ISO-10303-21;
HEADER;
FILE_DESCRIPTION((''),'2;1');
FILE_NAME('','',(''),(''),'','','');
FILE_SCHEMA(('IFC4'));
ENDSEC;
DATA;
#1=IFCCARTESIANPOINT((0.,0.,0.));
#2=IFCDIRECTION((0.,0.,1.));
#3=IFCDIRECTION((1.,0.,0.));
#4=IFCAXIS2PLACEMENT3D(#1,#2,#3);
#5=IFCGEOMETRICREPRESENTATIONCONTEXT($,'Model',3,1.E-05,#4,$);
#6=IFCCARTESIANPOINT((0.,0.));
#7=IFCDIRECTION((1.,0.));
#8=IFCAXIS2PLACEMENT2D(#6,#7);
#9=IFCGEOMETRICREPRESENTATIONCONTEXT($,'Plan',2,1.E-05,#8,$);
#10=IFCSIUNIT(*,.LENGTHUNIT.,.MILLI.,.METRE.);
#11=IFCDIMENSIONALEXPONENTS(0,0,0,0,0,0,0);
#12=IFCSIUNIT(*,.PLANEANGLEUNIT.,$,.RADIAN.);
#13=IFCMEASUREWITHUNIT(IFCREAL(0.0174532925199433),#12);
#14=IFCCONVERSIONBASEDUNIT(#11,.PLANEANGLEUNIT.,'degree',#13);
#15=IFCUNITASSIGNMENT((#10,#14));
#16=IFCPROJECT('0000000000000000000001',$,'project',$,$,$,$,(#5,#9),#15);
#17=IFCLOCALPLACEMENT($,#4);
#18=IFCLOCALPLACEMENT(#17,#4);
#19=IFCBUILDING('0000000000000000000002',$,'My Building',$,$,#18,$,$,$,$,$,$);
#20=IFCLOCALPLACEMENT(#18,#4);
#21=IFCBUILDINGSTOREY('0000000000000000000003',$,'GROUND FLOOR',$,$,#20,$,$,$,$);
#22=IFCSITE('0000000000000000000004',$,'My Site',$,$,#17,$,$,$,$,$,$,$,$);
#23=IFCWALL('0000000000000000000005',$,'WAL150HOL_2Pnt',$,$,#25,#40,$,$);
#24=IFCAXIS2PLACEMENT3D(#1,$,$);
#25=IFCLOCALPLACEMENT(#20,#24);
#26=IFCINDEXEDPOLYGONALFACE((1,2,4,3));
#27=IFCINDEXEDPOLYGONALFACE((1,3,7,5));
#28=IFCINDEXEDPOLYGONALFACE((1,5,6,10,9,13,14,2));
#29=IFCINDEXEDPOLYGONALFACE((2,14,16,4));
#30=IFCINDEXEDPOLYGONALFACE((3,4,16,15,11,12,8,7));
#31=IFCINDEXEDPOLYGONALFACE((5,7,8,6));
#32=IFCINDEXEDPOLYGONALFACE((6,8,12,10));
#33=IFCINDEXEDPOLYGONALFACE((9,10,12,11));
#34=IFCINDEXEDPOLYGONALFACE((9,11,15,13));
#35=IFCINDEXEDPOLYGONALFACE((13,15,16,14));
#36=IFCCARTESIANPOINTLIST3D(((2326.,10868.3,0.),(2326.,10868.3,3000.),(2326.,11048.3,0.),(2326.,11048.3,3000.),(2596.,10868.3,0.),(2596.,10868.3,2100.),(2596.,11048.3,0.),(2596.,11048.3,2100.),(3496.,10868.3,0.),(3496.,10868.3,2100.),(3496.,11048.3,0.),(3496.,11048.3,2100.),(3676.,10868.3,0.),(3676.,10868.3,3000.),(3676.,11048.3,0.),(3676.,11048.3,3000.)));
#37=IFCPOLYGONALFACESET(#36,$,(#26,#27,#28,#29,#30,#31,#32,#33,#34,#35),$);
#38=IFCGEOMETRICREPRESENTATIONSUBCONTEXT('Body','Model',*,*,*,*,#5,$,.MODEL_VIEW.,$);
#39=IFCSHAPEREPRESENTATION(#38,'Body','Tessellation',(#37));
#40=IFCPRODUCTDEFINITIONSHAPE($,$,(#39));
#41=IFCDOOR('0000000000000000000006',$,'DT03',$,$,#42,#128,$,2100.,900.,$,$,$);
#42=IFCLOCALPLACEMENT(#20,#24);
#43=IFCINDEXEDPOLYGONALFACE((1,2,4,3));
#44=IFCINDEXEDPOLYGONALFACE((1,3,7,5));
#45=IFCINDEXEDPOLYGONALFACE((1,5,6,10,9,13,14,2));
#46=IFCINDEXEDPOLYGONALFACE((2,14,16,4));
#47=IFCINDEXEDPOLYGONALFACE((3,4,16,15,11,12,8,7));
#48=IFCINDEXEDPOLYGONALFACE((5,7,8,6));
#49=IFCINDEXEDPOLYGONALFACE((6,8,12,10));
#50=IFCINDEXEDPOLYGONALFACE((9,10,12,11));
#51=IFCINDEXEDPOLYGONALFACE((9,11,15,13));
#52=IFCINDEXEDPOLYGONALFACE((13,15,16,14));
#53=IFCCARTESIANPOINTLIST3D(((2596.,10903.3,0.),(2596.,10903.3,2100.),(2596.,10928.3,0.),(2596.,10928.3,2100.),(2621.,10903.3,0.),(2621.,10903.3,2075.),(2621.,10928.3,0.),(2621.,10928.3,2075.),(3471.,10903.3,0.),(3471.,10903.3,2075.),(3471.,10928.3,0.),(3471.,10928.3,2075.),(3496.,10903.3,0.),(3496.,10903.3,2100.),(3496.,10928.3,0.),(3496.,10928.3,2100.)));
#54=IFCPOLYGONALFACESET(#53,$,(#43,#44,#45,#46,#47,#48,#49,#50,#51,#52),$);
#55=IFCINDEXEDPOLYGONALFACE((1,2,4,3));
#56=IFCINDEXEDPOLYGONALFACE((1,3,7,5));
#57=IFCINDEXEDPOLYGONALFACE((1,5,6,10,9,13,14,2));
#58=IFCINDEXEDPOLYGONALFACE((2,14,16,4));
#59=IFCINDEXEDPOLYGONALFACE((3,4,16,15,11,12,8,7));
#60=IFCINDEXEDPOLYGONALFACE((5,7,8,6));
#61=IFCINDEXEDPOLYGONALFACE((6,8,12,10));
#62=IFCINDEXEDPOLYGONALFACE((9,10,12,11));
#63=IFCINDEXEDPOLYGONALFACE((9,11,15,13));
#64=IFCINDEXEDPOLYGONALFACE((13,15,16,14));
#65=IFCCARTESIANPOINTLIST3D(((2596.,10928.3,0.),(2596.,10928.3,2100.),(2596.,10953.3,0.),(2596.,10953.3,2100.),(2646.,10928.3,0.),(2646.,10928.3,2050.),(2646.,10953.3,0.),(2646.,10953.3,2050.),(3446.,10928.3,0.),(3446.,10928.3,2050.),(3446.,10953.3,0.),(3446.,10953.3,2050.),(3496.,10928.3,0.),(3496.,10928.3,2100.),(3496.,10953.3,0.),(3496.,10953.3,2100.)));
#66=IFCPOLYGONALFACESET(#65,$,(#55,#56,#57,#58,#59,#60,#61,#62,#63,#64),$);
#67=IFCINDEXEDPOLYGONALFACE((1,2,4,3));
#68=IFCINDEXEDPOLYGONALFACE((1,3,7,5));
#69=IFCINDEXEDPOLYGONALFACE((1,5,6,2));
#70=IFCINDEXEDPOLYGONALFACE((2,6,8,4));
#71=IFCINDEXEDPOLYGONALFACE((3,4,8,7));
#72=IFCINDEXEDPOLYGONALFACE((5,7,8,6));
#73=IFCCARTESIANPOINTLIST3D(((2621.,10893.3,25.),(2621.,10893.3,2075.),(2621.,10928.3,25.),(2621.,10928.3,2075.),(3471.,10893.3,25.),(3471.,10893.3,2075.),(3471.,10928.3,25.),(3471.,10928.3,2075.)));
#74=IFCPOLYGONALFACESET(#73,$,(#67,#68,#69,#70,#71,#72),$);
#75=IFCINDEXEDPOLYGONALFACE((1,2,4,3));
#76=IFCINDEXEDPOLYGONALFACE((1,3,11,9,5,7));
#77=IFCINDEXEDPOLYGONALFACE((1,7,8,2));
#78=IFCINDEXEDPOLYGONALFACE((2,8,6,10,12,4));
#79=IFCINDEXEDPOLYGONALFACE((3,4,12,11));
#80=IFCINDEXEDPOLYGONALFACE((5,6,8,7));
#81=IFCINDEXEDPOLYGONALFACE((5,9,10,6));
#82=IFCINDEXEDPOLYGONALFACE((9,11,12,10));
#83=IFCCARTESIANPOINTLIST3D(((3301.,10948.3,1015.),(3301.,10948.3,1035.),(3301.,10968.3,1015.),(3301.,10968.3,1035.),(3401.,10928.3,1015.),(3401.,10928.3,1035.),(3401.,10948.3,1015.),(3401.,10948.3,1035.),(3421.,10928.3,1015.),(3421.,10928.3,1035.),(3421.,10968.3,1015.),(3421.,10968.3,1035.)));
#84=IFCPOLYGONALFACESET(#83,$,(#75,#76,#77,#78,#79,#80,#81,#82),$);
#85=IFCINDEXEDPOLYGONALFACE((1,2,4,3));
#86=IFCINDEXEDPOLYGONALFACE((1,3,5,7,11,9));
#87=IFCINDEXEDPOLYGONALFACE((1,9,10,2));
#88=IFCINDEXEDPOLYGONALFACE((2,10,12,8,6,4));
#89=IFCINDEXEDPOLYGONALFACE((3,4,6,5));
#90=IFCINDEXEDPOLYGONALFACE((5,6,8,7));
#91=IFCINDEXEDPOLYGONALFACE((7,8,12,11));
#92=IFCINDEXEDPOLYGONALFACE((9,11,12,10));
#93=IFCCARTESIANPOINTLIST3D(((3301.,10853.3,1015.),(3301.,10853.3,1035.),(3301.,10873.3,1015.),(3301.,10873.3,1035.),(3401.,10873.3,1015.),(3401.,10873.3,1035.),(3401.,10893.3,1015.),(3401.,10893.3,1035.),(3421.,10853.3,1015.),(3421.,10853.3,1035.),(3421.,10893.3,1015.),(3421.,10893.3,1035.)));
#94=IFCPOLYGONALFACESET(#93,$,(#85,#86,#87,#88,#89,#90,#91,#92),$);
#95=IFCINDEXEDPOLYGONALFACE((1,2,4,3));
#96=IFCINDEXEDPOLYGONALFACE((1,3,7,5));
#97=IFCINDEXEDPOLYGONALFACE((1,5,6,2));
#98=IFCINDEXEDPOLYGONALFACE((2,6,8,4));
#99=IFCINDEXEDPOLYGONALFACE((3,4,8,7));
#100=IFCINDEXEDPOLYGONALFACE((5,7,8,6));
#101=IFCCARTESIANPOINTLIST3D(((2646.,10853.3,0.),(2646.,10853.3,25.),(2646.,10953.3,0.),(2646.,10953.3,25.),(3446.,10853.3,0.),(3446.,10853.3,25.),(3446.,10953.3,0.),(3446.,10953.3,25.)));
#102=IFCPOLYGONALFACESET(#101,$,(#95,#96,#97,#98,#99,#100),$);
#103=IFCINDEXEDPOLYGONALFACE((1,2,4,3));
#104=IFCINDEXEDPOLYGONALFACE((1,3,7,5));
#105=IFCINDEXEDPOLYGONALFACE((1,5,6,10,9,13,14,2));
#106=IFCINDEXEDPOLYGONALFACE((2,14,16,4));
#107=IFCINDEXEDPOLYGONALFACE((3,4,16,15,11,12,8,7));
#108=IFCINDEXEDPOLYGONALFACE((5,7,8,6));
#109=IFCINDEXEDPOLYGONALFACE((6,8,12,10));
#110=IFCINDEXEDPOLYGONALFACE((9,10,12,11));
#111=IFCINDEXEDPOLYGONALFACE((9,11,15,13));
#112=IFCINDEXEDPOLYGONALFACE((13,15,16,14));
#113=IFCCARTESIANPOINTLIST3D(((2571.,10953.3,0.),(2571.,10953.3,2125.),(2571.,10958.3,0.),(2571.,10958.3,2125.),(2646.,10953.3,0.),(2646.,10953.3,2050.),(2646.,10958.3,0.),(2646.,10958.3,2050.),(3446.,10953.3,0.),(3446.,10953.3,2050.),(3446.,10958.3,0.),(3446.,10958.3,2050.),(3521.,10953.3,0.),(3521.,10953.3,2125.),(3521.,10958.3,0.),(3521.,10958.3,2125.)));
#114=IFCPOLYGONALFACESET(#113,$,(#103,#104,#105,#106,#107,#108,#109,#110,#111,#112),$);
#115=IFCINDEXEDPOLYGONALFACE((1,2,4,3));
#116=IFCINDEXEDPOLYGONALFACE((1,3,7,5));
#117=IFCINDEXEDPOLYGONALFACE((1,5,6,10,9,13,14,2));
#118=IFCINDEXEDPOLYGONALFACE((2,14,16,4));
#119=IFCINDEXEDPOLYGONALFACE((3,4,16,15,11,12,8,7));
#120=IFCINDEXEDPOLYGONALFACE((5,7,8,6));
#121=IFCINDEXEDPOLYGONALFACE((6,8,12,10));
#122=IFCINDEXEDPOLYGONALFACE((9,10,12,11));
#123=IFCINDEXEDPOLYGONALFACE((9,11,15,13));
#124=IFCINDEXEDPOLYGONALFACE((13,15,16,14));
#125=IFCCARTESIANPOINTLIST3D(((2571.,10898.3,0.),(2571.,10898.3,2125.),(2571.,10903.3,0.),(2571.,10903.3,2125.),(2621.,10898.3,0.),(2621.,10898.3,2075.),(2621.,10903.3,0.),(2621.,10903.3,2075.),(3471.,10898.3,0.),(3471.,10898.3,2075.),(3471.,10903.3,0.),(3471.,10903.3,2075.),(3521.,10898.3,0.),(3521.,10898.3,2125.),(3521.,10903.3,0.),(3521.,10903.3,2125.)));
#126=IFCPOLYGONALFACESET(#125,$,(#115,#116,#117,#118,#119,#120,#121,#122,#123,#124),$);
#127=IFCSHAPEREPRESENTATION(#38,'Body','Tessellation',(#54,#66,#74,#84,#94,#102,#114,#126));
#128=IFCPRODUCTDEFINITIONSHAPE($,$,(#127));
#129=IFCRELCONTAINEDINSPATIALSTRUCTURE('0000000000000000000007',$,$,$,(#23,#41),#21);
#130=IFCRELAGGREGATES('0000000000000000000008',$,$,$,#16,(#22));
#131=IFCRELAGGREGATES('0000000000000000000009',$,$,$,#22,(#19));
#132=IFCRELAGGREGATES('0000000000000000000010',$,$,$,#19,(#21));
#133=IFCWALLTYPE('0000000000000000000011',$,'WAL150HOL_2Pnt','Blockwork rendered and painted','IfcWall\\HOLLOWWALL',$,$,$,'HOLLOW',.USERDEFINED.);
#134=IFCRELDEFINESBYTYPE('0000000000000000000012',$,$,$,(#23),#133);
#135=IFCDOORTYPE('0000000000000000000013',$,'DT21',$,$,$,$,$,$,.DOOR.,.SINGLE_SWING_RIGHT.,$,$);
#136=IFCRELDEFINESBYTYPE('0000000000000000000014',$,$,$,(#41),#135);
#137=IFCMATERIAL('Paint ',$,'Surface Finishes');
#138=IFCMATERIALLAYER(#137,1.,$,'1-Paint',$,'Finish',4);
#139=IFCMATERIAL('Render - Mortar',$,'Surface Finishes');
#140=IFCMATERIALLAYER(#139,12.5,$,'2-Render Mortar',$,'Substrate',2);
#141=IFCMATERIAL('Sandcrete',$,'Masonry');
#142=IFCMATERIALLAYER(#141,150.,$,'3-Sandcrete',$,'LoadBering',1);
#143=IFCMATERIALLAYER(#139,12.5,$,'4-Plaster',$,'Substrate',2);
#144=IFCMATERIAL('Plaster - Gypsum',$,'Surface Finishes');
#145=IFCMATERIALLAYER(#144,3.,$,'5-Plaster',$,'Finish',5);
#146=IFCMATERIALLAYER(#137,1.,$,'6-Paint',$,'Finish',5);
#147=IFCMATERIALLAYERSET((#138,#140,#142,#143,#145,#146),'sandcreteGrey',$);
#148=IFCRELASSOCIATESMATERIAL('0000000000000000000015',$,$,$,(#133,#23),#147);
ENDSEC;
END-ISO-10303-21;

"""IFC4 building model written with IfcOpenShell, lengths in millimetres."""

from ifc_helpers import new_model, entity, si_unit, converted_unit, frame, origin_with_axes, origin_2d_with_axis, place, context, subcontext, project, spatial, line, indexed_curve, outline, extrude, shape, source, transform, mapped, material, layer, layer_set, layer_usage, type_object, type_shapes, element, fill, save


model = new_model("IFC4")

# Units and contexts
model_context = context("Model", 3, precision=1e-05, world=origin_with_axes())
plan_context = context("Plan", 2, precision=1e-05, world=origin_2d_with_axis())
body_context_1 = subcontext(model_context, "Body", "Model", "MODEL_VIEW")
body_context_2 = subcontext(plan_context, "Body", "Plan", "PLAN_VIEW")
ifc_project = project(units=[si_unit("LENGTHUNIT", "METRE", prefix="MILLI"), converted_unit("PLANEANGLEUNIT", "degree", entity("IfcReal", 0.0174532925199433), si_unit("PLANEANGLEUNIT", "RADIAN"), dimensions=[0, 0, 0, 0, 0, 0, 0])], contexts=[model_context, plan_context])

# Site, building, storey
site_placement = place(None, origin_with_axes())
site = spatial("IfcSite", under=ifc_project, at=site_placement, Name="My Site")
building_placement = place(site_placement, origin_with_axes())
building = spatial("IfcBuilding", under=site, at=building_placement, Name="My Building")
storey_placement = place(building_placement, origin_with_axes())
storey = spatial("IfcBuildingStorey", under=building, at=storey_placement, Name="GROUND FLOOR")

# Shared definitions
ifc_material_1 = material(Name="Paint ", Category="Surface Finishes")
ifc_layer_1 = layer(ifc_material_1, 1.0, Name="1-Paint", Category="Finish", Priority=4)
ifc_material_2 = material(Name="Render - Mortar", Category="Surface Finishes")
ifc_layer_2 = layer(ifc_material_2, 12.5, Name="2-Render Mortar", Category="Substrate", Priority=2)
ifc_material_3 = material(Name="Sandcrete", Category="Masonry")
ifc_layer_3 = layer(ifc_material_3, 150.0, Name="3-Sandcrete", Category="LoadBering", Priority=1)
ifc_layer_4 = layer(ifc_material_2, 12.5, Name="4-Plaster", Category="Substrate", Priority=2)
ifc_material_4 = material(Name="Plaster - Gypsum", Category="Surface Finishes")
ifc_layer_5 = layer(ifc_material_4, 3.0, Name="5-Plaster", Category="Finish", Priority=5)
ifc_layer_6 = layer(ifc_material_1, 1.0, Name="6-Paint", Category="Finish", Priority=5)
ifc_layer_set_1 = layer_set([ifc_layer_1, ifc_layer_2, ifc_layer_3, ifc_layer_4, ifc_layer_5, ifc_layer_6], Name="sandcreteGrey")
wall_type_1 = type_object("IfcWallType", Name="WAL150HOL_2Pnt", Description="Blockwork rendered and painted", ApplicableOccurrence="IfcWall\\HOLLOWWALL", ElementType="HOLLOW", PredefinedType="USERDEFINED", material=ifc_layer_set_1)

# Wall, opening, door
ifc_layer_usage_1 = layer_usage(ifc_layer_set_1, "AXIS2", "POSITIVE", 0.0)
wall_1_placement = place(storey_placement, frame((2326.0, 10868.3, 0.0), z_axis=(0.0, 0.0, 1.0), x_axis=(1.0, -0.000002, 0.0)))
wall_1 = element("IfcWall", 1, at=wall_1_placement, inside=storey, type_object=wall_type_1, material=ifc_layer_usage_1, Name="WAL150HOL_2Pnt", context=body_context_1, shape_type="SweptSolid", body=[
    extrude(outline(indexed_curve([(0.0, 0.0), (0.0, 180.0), (1350.0, 180.0), (1350.0, 0.0), (0.0, 0.0)], self_intersect=False)), origin_with_axes(), (0.0, 0.0, 1.0), 3000.0),
])
shared_shape_1 = source(origin_with_axes(), body_context_1, "Body", "SweptSolid", [
    extrude(outline(indexed_curve([(0.0, 0.0), (900.0, 0.0), (900.0, 2100.0), (0.0, 2100.0)], segments=[line(1, 2, 3, 4, 1)])), frame((0.0, -600.0, 0.0), z_axis=(0.0, -1.0, 0.0), x_axis=(1.0, 0.0, 0.0)), (0.0, 0.0, -1.0), 1200.0),
])
opening_1_placement = place(wall_1_placement, frame((270.0, 0.0, 0.0), z_axis=(0.0, 0.0, 1.0), x_axis=(1.0, 0.0, 0.0)))
opening_1 = element("IfcOpeningElement", 2, at=opening_1_placement, cuts=wall_1, PredefinedType="OPENING", context=body_context_1, shape_type="MappedRepresentation", body=[
    mapped(shared_shape_1, transform((0.0, 0.0, 0.0), x_axis=(1.0, 0.0, 0.0), y_axis=(0.0, 1.0, 0.0), z_axis=(0.0, 0.0, 1.0), scale=1.0)),
])
door_type_1 = type_object("IfcDoorType", Name="DT21", OperationType="SINGLE_SWING_RIGHT", PredefinedType="DOOR")
shared_shape_2 = source(origin_with_axes(), body_context_1, "Body", "SweptSolid", [
    extrude(outline(indexed_curve([(0.0, 0.0), (0.0, 2100.0), (900.0, 2100.0), (900.0, 0.0), (875.0, 0.0), (875.0, 2075.0), (25.0, 2075.0), (25.0, 0.0)], segments=[line(1, 2, 3, 4, 5, 6, 7, 8, 1)])), frame((0.0, 25.0, 0.0), z_axis=(0.0, -1.0, 0.0), x_axis=(1.0, 0.0, 0.0)), (0.0, 0.0, -1.0), 25.0),
    extrude(outline(indexed_curve([(0.0, 0.0), (0.0, 2100.0), (900.0, 2100.0), (900.0, 0.0), (850.0, 0.0), (850.0, 2050.0), (50.0, 2050.0), (50.0, 0.0)], segments=[line(1, 2, 3, 4, 5, 6, 7, 8, 1)])), frame((0.0, 0.0, 0.0), z_axis=(0.0, -1.0, 0.0), x_axis=(1.0, 0.0, 0.0)), (0.0, 0.0, -1.0), 25.0),
    extrude(outline(indexed_curve([(0.0, 0.0), (850.0, 0.0), (850.0, 35.0), (0.0, 35.0)], segments=[line(1, 2, 3, 4, 1)])), frame((25.0, 25.0, 25.0), z_axis=(0.0, 0.0, 1.0), x_axis=(1.0, 0.0, 0.0)), (0.0, 0.0, 1.0), 2050.0),
    extrude(outline(indexed_curve([(0.0, 0.0), (0.0, -40.0), (120.0, -40.0), (120.0, -20.0), (20.0, -20.0), (20.0, 0.0)], segments=[line(1, 2, 3, 4, 5, 6, 1)])), frame((75.0, 25.0, 1015.0), z_axis=(0.0, 0.0, 1.0), x_axis=(1.0, 0.0, 0.0)), (0.0, 0.0, 1.0), 20.0),
    extrude(outline(indexed_curve([(0.0, 0.0), (0.0, 40.0), (120.0, 40.0), (120.0, 20.0), (20.0, 20.0), (20.0, 0.0)], segments=[line(1, 2, 3, 4, 5, 6, 1)])), frame((75.0, 60.0, 1015.0), z_axis=(0.0, 0.0, 1.0), x_axis=(1.0, 0.0, 0.0)), (0.0, 0.0, 1.0), 20.0),
    extrude(outline(indexed_curve([(0.0, 0.0), (800.0, 0.0), (800.0, 100.0), (0.0, 100.0)], segments=[line(1, 2, 3, 4, 1)])), frame((50.0, 0.0, 0.0), z_axis=(0.0, 0.0, 1.0), x_axis=(1.0, 0.0, 0.0)), (0.0, 0.0, 1.0), 25.0),
    extrude(outline(indexed_curve([(0.0, 0.0), (0.0, 2125.0), (950.0, 2125.0), (950.0, 0.0), (875.0, 0.0), (875.0, 2050.0), (75.0, 2050.0), (75.0, 0.0)], segments=[line(1, 2, 3, 4, 5, 6, 7, 8, 1)])), frame((-25.0, -5.0, 0.0), z_axis=(0.0, -1.0, 0.0), x_axis=(1.0, 0.0, 0.0)), (0.0, 0.0, -1.0), 5.0),
    extrude(outline(indexed_curve([(0.0, 0.0), (0.0, 2125.0), (950.0, 2125.0), (950.0, 0.0), (900.0, 0.0), (900.0, 2075.0), (50.0, 2075.0), (50.0, 0.0)], segments=[line(1, 2, 3, 4, 5, 6, 7, 8, 1)])), frame((-25.0, 50.0, 0.0), z_axis=(0.0, -1.0, 0.0), x_axis=(1.0, 0.0, 0.0)), (0.0, 0.0, -1.0), 5.0),
])
shared_shape_3 = source(origin_with_axes(), body_context_2, "Body", "Curve2D", [
    entity("IfcIndexedPolyCurve", entity("IfcCartesianPointList2D", [[0.0, 0.0], [0.0, 50.0], [25.0, 50.0], [25.0, 25.0], [50.0, 25.0], [50.0, 0.0]]), [entity("IfcLineIndex", [1, 2, 3, 4, 5, 6, 1])]),
    entity("IfcIndexedPolyCurve", entity("IfcCartesianPointList2D", [[900.0, 0.0], [900.0, 50.0], [875.0, 50.0], [875.0, 25.0], [850.0, 25.0], [850.0, 0.0]]), [entity("IfcLineIndex", [1, 2, 3, 4, 5, 6, 1])]),
    entity("IfcTrimmedCurve", entity("IfcEllipse", entity("IfcAxis2Placement2D", entity("IfcCartesianPoint", [840.0, 50.0]), entity("IfcDirection", [1.0, 0.0])), 815.0, 850.0), [entity("IfcCartesianPoint", [840.0, 900.0])], [entity("IfcCartesianPoint", [25.0, 50.0])], True, "CARTESIAN"),
    entity("IfcIndexedPolyCurve", entity("IfcCartesianPointList2D", [[875.0, 50.0], [840.0, 50.0], [840.0, 900.0], [875.0, 900.0]]), [entity("IfcLineIndex", [1, 2, 3, 4, 1])]),
])
type_shapes(door_type_1, [shared_shape_2, shared_shape_3])
door_1_placement = place(opening_1_placement, frame((900.0, 85.0, 0.0), z_axis=(0.0, 0.0, 1.0), x_axis=(-1.0, 0.0, 0.0)))
door_1 = element("IfcDoor", 3, at=door_1_placement, inside=storey, type_object=door_type_1, Name="DT03", OverallHeight=2100.0, OverallWidth=900.0, shapes=[
    shape(body_context_1, "Body", "MappedRepresentation", [mapped(shared_shape_2, transform((0.0, 0.0, 0.0), x_axis=(1.0, 0.0, 0.0), y_axis=(0.0, 1.0, 0.0), z_axis=(0.0, 0.0, 1.0), scale=1.0))]),
    shape(body_context_2, "Body", "MappedRepresentation", [mapped(shared_shape_3, transform((0.0, 0.0, 0.0), x_axis=(1.0, 0.0, 0.0), y_axis=(0.0, 1.0, 0.0), z_axis=(0.0, 0.0, 1.0), scale=1.0))]),
])
fill(opening_1, door_1)

save(model, "model.ifc")
